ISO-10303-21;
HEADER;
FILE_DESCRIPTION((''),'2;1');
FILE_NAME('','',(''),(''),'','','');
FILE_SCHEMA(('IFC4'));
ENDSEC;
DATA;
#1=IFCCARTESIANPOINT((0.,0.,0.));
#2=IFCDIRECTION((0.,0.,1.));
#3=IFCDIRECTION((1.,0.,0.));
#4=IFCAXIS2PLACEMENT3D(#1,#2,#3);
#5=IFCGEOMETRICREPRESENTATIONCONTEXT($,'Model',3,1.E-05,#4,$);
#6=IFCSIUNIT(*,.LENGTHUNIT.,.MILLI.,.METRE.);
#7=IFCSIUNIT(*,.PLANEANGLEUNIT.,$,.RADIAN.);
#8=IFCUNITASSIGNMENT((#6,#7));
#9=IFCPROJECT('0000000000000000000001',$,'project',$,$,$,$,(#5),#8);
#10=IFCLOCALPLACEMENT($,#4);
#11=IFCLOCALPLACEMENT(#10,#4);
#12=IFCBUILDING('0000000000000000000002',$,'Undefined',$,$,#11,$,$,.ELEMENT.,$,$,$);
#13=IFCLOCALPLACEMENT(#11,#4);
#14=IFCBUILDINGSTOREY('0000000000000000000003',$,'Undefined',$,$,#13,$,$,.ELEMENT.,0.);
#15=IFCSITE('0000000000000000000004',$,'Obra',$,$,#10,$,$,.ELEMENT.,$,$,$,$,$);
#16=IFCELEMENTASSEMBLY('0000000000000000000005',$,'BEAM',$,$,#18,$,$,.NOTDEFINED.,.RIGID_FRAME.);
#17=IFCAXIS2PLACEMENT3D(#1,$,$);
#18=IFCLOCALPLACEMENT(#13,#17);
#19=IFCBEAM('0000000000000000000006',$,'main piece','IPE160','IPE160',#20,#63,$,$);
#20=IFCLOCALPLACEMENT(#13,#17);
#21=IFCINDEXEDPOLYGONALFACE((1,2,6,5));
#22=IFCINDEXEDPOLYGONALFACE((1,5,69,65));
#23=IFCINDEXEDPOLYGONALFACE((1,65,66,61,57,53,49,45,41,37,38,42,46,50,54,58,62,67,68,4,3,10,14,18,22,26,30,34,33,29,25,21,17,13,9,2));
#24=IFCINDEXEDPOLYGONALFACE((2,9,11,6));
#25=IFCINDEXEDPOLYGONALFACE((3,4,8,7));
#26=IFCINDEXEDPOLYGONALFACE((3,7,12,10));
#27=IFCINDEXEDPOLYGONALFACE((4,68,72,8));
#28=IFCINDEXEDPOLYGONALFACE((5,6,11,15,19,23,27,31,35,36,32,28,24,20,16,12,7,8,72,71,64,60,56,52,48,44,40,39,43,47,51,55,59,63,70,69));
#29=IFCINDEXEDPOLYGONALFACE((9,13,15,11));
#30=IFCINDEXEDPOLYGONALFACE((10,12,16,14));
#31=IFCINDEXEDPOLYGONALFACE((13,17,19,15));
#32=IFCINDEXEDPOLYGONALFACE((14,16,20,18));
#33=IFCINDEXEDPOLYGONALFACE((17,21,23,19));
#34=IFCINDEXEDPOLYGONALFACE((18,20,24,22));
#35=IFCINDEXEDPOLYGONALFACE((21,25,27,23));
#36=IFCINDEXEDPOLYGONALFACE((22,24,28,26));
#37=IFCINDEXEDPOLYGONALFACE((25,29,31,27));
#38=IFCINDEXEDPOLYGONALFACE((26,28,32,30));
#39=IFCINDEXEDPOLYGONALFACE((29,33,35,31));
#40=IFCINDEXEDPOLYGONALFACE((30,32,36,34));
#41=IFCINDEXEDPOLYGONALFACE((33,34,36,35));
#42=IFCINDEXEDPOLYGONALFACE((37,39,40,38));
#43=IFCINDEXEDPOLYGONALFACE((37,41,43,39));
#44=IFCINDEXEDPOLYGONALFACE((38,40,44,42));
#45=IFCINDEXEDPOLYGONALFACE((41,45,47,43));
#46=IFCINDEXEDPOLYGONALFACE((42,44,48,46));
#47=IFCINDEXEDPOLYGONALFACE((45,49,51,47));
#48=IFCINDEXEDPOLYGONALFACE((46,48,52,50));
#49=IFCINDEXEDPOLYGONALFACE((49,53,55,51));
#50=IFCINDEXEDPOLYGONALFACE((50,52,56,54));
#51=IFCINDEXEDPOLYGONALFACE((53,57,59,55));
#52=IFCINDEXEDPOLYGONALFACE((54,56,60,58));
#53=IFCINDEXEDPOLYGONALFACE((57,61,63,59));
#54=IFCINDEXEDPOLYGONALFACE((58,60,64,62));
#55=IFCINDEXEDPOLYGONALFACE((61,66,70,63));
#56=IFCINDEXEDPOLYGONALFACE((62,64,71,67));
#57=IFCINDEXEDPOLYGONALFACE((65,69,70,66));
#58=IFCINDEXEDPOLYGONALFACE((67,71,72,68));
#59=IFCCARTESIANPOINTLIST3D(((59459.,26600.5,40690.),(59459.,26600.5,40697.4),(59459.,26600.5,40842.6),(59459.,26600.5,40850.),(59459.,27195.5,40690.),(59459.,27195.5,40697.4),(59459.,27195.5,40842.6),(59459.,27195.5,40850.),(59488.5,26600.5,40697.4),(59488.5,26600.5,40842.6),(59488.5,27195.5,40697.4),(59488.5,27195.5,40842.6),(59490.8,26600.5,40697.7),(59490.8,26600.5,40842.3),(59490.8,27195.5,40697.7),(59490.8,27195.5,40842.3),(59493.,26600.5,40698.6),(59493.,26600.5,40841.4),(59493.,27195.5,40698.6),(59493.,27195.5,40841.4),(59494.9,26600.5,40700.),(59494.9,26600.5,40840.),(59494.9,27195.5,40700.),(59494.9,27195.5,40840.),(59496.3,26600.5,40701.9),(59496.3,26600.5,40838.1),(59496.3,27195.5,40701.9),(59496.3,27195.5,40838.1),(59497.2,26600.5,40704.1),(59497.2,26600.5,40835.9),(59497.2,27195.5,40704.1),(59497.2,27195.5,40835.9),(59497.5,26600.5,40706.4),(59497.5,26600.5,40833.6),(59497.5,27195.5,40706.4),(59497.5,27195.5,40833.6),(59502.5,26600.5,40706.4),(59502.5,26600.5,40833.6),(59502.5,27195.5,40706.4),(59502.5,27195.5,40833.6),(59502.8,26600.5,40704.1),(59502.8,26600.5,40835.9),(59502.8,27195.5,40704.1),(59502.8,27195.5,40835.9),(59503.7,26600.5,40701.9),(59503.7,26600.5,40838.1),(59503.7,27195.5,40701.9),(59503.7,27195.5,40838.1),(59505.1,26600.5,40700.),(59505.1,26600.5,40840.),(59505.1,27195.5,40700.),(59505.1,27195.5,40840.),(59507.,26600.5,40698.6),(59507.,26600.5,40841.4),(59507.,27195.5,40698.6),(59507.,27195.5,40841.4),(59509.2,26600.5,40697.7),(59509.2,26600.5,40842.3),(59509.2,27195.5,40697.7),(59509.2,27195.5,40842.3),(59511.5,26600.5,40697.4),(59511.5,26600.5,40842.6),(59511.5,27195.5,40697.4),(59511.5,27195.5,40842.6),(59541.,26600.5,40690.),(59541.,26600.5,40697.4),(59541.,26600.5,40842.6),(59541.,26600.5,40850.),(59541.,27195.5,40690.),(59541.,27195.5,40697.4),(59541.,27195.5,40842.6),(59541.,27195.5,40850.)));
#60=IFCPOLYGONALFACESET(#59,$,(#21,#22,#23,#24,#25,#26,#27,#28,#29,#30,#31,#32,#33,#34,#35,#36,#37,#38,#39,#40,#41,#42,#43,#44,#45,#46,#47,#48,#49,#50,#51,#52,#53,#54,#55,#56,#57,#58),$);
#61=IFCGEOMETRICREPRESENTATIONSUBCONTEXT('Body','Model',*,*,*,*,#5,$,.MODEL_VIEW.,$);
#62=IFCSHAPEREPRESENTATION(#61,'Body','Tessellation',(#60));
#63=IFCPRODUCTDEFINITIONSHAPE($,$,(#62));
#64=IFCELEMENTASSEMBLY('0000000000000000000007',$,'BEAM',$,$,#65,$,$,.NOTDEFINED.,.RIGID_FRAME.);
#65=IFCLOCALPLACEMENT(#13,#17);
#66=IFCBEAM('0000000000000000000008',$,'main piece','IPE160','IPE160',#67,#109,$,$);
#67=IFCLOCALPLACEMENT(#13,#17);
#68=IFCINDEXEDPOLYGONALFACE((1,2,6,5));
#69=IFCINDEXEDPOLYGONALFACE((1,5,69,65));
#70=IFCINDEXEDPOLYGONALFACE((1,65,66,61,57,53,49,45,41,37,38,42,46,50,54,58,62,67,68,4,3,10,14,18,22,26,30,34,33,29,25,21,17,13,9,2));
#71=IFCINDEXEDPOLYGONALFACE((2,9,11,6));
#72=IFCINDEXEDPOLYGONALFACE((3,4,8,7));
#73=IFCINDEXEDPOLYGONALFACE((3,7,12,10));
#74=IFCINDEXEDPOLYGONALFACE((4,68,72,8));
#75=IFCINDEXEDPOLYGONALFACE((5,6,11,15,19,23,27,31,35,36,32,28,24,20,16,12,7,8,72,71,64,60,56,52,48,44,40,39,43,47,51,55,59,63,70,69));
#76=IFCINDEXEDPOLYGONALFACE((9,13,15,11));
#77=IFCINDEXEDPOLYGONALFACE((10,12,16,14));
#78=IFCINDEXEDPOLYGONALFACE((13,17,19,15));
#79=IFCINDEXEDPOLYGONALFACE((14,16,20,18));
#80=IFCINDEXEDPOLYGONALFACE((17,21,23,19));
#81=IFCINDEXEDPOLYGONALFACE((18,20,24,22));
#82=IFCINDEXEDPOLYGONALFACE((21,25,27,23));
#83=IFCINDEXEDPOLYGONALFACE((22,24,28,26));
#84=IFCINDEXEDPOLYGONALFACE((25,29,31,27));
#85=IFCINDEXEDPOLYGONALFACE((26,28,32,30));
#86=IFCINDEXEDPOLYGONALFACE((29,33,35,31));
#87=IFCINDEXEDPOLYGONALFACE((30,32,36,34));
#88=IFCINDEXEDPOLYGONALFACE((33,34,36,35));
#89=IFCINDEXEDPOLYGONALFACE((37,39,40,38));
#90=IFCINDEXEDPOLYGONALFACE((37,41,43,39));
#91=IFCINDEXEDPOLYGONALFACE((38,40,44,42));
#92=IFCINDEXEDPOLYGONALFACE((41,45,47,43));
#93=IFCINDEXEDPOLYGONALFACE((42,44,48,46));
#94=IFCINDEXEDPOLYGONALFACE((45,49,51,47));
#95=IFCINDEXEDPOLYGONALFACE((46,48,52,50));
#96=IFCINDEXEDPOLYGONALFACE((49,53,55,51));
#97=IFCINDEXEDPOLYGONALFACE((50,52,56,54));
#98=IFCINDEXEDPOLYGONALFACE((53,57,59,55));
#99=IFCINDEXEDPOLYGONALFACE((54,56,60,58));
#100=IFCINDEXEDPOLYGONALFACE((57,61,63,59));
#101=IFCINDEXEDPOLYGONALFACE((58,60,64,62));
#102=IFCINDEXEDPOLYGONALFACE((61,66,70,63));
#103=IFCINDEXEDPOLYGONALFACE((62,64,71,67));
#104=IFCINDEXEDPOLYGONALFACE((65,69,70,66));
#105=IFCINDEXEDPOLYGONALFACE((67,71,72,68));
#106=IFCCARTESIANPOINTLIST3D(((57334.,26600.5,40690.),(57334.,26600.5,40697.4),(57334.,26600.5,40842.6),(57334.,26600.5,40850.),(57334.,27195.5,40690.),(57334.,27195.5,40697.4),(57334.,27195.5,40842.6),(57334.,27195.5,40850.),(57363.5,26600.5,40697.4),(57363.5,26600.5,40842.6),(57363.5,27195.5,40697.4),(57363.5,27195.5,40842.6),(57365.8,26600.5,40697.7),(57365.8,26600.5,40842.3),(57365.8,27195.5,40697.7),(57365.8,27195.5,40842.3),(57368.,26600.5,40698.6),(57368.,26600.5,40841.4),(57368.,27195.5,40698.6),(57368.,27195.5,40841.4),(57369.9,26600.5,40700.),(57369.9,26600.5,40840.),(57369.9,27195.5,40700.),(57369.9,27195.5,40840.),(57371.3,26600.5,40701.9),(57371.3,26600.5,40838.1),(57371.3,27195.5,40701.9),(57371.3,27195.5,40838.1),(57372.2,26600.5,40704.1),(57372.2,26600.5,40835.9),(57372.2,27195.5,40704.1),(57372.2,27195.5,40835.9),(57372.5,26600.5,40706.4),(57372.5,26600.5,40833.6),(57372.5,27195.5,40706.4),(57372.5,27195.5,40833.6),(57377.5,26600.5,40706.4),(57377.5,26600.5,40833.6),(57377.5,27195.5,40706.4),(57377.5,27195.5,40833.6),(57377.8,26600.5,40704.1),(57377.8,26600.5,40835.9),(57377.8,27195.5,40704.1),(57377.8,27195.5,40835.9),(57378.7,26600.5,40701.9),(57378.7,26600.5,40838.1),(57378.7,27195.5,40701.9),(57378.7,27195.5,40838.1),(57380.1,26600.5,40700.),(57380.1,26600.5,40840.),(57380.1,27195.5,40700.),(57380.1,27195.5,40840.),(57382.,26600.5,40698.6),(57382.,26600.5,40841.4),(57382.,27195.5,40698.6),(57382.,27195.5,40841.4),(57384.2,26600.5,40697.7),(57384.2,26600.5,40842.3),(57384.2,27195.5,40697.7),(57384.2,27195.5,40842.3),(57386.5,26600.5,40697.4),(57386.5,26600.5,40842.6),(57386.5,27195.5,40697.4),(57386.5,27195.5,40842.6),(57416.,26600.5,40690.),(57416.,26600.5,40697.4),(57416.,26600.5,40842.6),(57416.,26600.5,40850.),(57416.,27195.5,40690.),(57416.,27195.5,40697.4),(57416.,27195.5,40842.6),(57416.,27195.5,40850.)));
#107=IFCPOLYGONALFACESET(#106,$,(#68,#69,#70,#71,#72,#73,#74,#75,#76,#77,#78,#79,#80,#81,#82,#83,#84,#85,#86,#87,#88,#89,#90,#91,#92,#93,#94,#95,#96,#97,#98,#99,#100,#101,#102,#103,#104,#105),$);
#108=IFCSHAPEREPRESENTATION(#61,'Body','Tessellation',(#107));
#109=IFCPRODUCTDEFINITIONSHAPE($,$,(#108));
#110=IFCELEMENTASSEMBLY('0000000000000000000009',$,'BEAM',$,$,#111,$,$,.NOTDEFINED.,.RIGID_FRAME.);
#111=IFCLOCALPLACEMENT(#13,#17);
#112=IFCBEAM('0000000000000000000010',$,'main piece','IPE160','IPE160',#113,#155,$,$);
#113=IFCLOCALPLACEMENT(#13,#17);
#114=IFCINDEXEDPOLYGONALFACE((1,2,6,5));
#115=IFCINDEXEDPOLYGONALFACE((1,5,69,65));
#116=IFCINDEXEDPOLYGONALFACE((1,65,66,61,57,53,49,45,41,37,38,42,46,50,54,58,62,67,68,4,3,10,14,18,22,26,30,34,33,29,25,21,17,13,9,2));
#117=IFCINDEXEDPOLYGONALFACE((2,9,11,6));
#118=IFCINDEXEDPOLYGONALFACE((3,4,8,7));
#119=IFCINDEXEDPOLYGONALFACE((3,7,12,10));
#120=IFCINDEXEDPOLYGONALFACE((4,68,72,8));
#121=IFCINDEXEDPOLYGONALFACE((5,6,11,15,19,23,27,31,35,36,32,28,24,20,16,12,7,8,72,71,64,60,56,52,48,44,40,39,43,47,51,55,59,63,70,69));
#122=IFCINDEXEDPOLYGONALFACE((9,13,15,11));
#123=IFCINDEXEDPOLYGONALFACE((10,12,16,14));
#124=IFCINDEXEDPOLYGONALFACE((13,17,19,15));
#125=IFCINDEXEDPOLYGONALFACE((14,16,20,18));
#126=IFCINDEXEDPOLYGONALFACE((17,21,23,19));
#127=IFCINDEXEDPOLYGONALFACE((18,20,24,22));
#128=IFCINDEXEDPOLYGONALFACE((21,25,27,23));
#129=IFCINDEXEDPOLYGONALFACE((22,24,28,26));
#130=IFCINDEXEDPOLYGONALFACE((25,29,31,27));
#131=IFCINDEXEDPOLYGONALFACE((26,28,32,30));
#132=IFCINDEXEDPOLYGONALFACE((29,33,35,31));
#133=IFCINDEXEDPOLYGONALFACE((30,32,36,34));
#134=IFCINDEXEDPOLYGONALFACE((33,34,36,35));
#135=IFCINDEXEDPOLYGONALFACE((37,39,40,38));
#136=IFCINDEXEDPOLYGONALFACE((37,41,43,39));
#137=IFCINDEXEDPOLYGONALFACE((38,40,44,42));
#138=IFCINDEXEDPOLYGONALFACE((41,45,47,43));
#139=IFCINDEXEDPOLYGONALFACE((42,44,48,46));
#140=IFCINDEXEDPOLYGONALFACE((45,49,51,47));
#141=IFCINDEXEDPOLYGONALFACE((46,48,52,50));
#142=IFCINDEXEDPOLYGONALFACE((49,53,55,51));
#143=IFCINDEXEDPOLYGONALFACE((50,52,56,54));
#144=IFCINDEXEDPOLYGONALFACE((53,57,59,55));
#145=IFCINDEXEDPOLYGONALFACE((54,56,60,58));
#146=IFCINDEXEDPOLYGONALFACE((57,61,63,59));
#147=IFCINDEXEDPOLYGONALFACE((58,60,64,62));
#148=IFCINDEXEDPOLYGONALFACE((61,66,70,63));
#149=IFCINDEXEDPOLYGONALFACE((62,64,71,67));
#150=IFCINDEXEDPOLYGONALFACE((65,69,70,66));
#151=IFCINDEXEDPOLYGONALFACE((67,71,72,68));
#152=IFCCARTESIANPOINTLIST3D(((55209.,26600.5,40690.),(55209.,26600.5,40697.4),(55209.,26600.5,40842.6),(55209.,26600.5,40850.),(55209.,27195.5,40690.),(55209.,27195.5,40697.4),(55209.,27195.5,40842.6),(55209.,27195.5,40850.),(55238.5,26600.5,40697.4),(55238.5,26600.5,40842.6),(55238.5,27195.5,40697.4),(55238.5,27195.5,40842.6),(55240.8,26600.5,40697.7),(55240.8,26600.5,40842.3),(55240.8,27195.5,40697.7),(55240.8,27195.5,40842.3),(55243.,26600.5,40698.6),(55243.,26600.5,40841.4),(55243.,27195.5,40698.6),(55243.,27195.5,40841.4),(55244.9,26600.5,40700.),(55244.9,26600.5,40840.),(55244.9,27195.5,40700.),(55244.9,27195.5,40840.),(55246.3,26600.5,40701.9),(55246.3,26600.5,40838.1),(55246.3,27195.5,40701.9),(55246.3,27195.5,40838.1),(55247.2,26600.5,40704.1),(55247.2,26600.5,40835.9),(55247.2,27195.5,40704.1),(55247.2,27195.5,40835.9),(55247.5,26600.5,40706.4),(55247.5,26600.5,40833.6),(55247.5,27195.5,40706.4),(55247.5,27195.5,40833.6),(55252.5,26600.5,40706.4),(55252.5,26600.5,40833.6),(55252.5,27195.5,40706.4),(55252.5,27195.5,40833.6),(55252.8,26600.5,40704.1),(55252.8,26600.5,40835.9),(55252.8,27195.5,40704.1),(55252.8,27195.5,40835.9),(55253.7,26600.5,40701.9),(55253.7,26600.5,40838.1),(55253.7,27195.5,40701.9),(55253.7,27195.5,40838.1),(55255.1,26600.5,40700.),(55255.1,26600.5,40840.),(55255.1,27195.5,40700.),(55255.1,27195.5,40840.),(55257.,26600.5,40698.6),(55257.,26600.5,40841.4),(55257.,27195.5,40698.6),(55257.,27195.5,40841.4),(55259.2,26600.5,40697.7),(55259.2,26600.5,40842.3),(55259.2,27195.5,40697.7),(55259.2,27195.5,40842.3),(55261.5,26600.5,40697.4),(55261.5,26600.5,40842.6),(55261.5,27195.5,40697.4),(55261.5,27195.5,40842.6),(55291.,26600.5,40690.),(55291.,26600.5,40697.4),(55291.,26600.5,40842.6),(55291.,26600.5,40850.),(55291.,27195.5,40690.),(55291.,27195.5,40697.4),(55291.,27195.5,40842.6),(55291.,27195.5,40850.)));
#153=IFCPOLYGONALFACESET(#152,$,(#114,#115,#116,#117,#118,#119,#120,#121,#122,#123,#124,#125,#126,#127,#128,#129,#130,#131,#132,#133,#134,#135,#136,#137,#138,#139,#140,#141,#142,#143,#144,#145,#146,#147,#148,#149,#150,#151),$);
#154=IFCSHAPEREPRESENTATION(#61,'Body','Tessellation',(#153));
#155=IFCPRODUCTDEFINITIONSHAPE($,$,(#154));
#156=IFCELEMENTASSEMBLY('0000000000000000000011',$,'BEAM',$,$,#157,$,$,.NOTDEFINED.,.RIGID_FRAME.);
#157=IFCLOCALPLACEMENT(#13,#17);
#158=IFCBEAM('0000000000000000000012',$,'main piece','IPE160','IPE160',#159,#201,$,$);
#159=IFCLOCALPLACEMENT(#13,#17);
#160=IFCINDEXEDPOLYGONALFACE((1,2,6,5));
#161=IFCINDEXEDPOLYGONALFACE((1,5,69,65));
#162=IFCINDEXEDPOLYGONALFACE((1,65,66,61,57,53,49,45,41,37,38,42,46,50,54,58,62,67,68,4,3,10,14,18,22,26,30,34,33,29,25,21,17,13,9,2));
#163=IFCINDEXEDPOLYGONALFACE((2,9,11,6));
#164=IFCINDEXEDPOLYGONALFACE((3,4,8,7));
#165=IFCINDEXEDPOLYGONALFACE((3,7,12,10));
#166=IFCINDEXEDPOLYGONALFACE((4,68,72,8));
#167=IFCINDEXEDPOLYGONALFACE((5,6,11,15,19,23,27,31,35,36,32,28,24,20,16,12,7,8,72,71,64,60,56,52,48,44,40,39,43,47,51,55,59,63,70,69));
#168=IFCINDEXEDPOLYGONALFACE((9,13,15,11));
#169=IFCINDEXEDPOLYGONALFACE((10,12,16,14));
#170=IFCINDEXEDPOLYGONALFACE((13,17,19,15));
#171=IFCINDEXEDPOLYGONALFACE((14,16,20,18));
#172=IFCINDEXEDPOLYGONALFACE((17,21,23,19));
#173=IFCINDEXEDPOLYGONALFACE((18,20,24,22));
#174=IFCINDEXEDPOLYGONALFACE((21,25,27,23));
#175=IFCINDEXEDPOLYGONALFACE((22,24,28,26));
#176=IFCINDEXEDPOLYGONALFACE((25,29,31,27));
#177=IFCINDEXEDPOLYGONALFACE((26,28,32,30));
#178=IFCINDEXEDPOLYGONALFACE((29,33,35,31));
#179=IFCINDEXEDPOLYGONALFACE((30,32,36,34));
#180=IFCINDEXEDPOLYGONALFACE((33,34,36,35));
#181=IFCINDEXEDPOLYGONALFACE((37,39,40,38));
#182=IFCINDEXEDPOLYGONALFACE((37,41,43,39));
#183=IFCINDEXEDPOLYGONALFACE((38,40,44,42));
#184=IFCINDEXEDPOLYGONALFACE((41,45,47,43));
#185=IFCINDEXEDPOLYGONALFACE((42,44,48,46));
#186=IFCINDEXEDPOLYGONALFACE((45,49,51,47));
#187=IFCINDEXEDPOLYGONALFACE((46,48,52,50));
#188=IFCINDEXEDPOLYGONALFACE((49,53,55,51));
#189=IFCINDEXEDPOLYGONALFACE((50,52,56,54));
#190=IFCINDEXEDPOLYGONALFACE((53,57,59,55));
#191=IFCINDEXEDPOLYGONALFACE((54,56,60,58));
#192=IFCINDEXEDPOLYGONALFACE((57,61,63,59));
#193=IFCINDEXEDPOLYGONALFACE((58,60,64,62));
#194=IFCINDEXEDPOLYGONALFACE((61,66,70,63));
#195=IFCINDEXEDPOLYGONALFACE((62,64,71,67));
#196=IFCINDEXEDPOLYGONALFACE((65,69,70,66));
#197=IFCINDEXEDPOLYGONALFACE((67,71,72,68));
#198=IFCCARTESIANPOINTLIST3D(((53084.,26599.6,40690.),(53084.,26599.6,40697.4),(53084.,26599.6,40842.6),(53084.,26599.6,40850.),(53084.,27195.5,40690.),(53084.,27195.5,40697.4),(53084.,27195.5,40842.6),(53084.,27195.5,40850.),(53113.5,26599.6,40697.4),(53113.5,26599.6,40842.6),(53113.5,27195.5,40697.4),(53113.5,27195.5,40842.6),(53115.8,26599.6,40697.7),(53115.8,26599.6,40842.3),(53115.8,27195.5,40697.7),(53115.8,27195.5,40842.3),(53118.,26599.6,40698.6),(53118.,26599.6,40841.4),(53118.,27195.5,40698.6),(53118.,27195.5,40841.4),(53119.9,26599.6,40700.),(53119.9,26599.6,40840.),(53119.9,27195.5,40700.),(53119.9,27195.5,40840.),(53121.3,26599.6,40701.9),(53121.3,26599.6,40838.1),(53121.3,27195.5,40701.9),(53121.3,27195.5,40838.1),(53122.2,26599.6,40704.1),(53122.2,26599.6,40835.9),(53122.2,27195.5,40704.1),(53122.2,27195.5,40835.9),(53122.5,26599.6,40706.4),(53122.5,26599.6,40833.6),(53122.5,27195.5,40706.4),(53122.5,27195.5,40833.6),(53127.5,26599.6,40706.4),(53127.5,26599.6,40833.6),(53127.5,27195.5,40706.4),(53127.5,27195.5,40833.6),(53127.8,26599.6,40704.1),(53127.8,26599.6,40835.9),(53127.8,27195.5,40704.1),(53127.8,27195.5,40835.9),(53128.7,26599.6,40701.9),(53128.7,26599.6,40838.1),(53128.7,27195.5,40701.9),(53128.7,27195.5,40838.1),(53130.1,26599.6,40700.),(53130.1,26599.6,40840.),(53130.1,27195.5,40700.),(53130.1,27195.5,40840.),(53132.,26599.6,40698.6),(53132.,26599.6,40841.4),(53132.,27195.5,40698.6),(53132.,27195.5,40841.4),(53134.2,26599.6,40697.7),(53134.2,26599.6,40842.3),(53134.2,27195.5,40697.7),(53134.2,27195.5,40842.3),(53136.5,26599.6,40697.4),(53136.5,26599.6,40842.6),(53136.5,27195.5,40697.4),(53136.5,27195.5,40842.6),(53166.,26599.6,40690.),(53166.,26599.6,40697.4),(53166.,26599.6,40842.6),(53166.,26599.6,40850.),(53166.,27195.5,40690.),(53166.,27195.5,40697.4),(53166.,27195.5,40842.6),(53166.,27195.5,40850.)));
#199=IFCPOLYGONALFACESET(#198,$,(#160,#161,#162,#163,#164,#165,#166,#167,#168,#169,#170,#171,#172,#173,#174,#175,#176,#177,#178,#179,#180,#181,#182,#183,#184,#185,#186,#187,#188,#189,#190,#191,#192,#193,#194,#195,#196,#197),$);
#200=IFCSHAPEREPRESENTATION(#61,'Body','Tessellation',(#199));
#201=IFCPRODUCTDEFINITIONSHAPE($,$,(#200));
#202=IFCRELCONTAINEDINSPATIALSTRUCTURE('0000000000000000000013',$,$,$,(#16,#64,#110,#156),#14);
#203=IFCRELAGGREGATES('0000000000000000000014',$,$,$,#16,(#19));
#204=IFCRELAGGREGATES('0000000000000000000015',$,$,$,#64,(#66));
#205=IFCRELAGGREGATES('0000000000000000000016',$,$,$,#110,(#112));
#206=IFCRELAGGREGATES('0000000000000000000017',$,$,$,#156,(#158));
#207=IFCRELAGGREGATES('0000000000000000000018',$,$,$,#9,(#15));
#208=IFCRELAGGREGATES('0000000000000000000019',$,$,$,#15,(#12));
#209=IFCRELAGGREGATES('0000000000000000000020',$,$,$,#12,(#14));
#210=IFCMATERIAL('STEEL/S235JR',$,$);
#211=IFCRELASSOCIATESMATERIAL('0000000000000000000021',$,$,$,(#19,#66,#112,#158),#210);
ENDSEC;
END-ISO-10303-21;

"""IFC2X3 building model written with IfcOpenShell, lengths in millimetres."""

from ifc_helpers import new_model, si_unit, frame, origin_with_axes, origin_2d_with_axis, place, context, subcontext, project, spatial, i_section, extrude, material, element, aggregate, save


model = new_model("IFC2X3")

# Units and contexts
model_context = context("Model", 3, precision=1e-05, world=origin_with_axes())
body_context = subcontext(model_context, "Body", "Model", "MODEL_VIEW")
ifc_project = project(units=[si_unit("LENGTHUNIT", "METRE", prefix="MILLI"), si_unit("PLANEANGLEUNIT", "RADIAN")], contexts=[model_context])

# Site, building, storey
site_placement = place(None, origin_with_axes())
site = spatial("IfcSite", under=ifc_project, at=site_placement, Name="Obra", CompositionType="ELEMENT")
building_placement = place(site_placement, origin_with_axes())
building = spatial("IfcBuilding", under=site, at=building_placement, Name="Undefined", CompositionType="ELEMENT")
storey_placement = place(building_placement, origin_with_axes())
storey = spatial("IfcBuildingStorey", under=building, at=storey_placement, Name="Undefined", CompositionType="ELEMENT", Elevation=0.0)

# Shared definitions
ifc_material_1 = material(Name="STEEL/S235JR")

# Element assemblies, beams
assembly_1_placement = place(storey_placement, origin_with_axes())
assembly_1 = element("IfcElementAssembly", 1, at=assembly_1_placement, inside=storey, Name="BEAM", AssemblyPlace="NOTDEFINED", PredefinedType="RIGID_FRAME")
beam_1_placement = place(assembly_1_placement, frame((59500.0, 26600.5, 40770.0), z_axis=(0.0, 0.0, 1.0), x_axis=(0.0, 1.0, 0.0)))
beam_1 = element("IfcBeam", 2, at=beam_1_placement, material=ifc_material_1, Name="main piece", Description="IPE160", ObjectType="IPE160", context=body_context, shape_type="SweptSolid", body=[
    extrude(i_section(OverallWidth=82.0, OverallDepth=160.0, WebThickness=5.0, FlangeThickness=7.4, FilletRadius=9.0, at=origin_2d_with_axis()), frame((595.0, 0.0, 0.0), z_axis=(-1.0, 0.0, 0.0), x_axis=(0.0, -1.0, 0.0)), (0.0, 0.0, 1.0), 595.0),
])
aggregate(assembly_1, [beam_1])
assembly_2_placement = place(storey_placement, origin_with_axes())
assembly_2 = element("IfcElementAssembly", 3, at=assembly_2_placement, inside=storey, Name="BEAM", AssemblyPlace="NOTDEFINED", PredefinedType="RIGID_FRAME")
beam_2_placement = place(assembly_2_placement, frame((57375.0, 27195.5, 40770.0), z_axis=(0.0, 0.0, 1.0), x_axis=(0.0, -1.0, 0.0)))
beam_2 = element("IfcBeam", 4, at=beam_2_placement, material=ifc_material_1, Name="main piece", Description="IPE160", ObjectType="IPE160", context=body_context, shape_type="SweptSolid", body=[
    extrude(i_section(OverallWidth=82.0, OverallDepth=160.0, WebThickness=5.0, FlangeThickness=7.4, FilletRadius=9.0, at=origin_2d_with_axis()), frame((595.0, 0.0, 0.0), z_axis=(-1.0, 0.0, 0.0), x_axis=(0.0, -1.0, 0.0)), (0.0, 0.0, 1.0), 595.0),
])
aggregate(assembly_2, [beam_2])
assembly_3_placement = place(storey_placement, origin_with_axes())
assembly_3 = element("IfcElementAssembly", 5, at=assembly_3_placement, inside=storey, Name="BEAM", AssemblyPlace="NOTDEFINED", PredefinedType="RIGID_FRAME")
beam_3_placement = place(assembly_3_placement, frame((55250.0, 26600.5, 40770.0), z_axis=(0.0, 0.0, 1.0), x_axis=(0.0, 1.0, 0.0)))
beam_3 = element("IfcBeam", 6, at=beam_3_placement, material=ifc_material_1, Name="main piece", Description="IPE160", ObjectType="IPE160", context=body_context, shape_type="SweptSolid", body=[
    extrude(i_section(OverallWidth=82.0, OverallDepth=160.0, WebThickness=5.0, FlangeThickness=7.4, FilletRadius=9.0, at=origin_2d_with_axis()), frame((595.0, 0.0, 0.0), z_axis=(-1.0, 0.0, 0.0), x_axis=(0.0, -1.0, 0.0)), (0.0, 0.0, 1.0), 595.0),
])
aggregate(assembly_3, [beam_3])
assembly_4_placement = place(storey_placement, origin_with_axes())
assembly_4 = element("IfcElementAssembly", 7, at=assembly_4_placement, inside=storey, Name="BEAM", AssemblyPlace="NOTDEFINED", PredefinedType="RIGID_FRAME")
beam_4_placement = place(assembly_4_placement, frame((53125.0, 26599.6, 40770.0), z_axis=(0.0, 0.0, 1.0), x_axis=(0.0, 1.0, 0.0)))
beam_4 = element("IfcBeam", 8, at=beam_4_placement, material=ifc_material_1, Name="main piece", Description="IPE160", ObjectType="IPE160", context=body_context, shape_type="SweptSolid", body=[
    extrude(i_section(OverallWidth=82.0, OverallDepth=160.0, WebThickness=5.0, FlangeThickness=7.4, FilletRadius=9.0, at=origin_2d_with_axis()), frame((595.9, 0.0, 0.0), z_axis=(-1.0, 0.0, 0.0), x_axis=(0.0, -1.0, 0.0)), (0.0, 0.0, 1.0), 595.9),
])
aggregate(assembly_4, [beam_4])

save(model, "model.ifc")
